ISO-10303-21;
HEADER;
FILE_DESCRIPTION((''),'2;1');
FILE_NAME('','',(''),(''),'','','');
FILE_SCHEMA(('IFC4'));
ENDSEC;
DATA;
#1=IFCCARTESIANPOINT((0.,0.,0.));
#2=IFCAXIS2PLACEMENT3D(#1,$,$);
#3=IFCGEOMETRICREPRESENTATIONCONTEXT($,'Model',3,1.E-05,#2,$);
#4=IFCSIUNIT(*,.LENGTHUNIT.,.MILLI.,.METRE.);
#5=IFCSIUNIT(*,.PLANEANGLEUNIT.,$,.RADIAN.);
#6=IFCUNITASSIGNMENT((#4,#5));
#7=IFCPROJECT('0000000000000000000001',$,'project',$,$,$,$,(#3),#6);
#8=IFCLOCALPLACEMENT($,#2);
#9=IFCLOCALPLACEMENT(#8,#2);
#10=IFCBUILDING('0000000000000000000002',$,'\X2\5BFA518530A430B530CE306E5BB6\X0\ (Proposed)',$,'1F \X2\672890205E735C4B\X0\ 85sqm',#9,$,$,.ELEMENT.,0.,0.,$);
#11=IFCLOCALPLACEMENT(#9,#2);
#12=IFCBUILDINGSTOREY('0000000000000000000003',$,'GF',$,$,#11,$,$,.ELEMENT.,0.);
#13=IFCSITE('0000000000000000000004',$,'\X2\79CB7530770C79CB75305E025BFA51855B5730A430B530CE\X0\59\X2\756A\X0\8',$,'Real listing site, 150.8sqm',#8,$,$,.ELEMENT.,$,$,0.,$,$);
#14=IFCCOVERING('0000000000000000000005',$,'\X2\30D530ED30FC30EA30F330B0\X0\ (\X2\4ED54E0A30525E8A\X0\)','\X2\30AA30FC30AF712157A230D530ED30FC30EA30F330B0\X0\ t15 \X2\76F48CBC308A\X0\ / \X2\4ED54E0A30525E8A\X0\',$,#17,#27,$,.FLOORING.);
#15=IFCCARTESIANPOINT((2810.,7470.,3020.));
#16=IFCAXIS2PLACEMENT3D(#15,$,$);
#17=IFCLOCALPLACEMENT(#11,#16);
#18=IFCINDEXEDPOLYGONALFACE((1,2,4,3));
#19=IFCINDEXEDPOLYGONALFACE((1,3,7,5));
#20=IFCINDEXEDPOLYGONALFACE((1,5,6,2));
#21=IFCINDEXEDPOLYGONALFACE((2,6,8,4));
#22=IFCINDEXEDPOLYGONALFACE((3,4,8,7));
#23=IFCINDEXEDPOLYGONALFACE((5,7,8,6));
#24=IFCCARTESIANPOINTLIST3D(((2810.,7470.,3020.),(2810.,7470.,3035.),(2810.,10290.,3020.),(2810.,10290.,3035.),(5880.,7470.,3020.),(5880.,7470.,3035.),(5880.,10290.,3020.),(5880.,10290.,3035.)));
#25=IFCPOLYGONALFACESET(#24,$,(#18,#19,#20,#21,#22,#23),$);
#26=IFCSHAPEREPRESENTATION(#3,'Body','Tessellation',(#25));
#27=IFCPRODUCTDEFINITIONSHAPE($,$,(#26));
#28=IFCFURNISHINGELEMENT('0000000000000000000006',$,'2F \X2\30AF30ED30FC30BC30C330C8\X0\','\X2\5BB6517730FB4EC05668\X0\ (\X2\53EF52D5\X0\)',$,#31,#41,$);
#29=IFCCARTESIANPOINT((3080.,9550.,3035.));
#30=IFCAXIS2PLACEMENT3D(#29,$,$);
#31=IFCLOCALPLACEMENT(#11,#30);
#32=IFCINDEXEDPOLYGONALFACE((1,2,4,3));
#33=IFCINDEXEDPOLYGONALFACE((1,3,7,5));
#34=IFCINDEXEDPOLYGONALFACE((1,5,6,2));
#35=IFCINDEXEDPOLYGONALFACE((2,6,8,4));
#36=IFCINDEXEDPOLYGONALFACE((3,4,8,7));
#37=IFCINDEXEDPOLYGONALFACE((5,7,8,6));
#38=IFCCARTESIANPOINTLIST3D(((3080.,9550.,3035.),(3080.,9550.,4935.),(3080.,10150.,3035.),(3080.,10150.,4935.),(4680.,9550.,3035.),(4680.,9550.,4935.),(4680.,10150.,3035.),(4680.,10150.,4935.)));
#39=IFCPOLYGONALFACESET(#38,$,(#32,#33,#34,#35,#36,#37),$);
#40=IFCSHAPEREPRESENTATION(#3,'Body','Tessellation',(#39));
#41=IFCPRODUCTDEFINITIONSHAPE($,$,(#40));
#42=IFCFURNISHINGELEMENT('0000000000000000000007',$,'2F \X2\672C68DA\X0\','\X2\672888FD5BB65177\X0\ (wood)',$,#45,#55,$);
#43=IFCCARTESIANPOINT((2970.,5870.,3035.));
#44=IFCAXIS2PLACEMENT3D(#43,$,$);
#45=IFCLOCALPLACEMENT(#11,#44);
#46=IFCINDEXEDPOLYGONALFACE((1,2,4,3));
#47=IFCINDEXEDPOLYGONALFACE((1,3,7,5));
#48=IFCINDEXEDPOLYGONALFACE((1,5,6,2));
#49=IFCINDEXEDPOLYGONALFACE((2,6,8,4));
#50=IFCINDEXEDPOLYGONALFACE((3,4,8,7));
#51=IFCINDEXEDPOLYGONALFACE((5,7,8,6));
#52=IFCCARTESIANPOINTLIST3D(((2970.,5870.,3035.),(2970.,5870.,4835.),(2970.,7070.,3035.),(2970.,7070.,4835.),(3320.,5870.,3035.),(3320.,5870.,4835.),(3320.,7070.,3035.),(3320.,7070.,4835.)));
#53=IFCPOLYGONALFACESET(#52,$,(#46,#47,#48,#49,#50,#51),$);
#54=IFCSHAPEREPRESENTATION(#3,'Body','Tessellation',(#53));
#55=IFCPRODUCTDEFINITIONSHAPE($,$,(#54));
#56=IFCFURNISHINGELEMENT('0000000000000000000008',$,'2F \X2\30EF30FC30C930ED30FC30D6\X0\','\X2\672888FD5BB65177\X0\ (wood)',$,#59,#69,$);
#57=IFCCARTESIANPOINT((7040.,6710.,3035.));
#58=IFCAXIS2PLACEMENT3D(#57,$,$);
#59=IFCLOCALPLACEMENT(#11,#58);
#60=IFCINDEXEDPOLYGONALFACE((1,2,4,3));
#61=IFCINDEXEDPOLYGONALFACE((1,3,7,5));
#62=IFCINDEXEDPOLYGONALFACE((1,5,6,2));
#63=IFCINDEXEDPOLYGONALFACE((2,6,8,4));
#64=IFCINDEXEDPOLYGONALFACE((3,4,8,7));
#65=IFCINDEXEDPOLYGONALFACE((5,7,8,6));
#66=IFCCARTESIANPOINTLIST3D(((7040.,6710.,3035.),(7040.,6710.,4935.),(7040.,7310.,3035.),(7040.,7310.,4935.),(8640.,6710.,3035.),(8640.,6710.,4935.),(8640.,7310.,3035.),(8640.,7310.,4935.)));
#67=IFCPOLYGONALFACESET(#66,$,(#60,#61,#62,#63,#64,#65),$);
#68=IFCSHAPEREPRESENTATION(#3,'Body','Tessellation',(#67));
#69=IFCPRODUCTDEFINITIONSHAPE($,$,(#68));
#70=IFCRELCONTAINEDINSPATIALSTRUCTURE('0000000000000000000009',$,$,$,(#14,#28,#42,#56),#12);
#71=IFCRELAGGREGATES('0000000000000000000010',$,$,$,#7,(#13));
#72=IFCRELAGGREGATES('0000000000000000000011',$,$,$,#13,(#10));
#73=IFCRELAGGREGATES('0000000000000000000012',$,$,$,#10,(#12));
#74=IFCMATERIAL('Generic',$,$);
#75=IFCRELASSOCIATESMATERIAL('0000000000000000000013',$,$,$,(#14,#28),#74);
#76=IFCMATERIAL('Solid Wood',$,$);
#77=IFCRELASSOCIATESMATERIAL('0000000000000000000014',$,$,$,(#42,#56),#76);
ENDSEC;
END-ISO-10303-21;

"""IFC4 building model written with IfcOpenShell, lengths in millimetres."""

from ifc_helpers import new_model, si_unit, frame, frame_2d, origin, place, context, project, spatial, rectangle, extrude, material, element, save


model = new_model("IFC4")

# Units and contexts
model_context = context("Model", 3, precision=1e-05, world=origin())
ifc_project = project(units=[si_unit("LENGTHUNIT", "METRE", prefix="MILLI"), si_unit("PLANEANGLEUNIT", "RADIAN")], contexts=[model_context])

# Site, building, storey
site_placement = place(None, origin())
site = spatial("IfcSite", under=ifc_project, at=site_placement, Name="秋田県秋田市寺内字イサノ59番8", ObjectType="Real listing site, 150.8sqm", CompositionType="ELEMENT", RefElevation=0.0)
building_placement = place(site_placement, origin())
building = spatial("IfcBuilding", under=site, at=building_placement, Name="寺内イサノの家 (Proposed)", ObjectType="1F 木造平屋 85sqm", CompositionType="ELEMENT", ElevationOfRefHeight=0.0, ElevationOfTerrain=0.0)
storey_placement = place(building_placement, origin())
storey = spatial("IfcBuildingStorey", under=building, at=storey_placement, Name="GF", CompositionType="ELEMENT", Elevation=0.0)

# Shared definitions
ifc_material_1 = material(Name="Solid Wood")

# Shared definitions
ifc_material_2 = material(Name="Generic")

# Covering
covering_placement = place(storey_placement, frame((2810.0, 7470.0, 3020.0)))
element("IfcCovering", 1, at=covering_placement, inside=storey, material=ifc_material_2, Name="フローリング (仕上げ床)", Description="オーク無垢フローリング t15 直貼り / 仕上げ床", PredefinedType="FLOORING", context=model_context, shape_type="SweptSolid", body=[
    extrude(rectangle(XDim=3070.0, YDim=2820.0, at=frame_2d((1535.0, 1410.0))), frame((2810.0, 7470.0, 3020.0)), (0.0, 0.0, 1.0), 15.0),
])

# Furnishing elements
furnishing_1_placement = place(storey_placement, frame((3080.0, 9550.0, 3035.0)))
element("IfcFurnishingElement", 2, at=furnishing_1_placement, inside=storey, material=ifc_material_2, Name="2F クローゼット", Description="家具・什器 (可動)", context=model_context, shape_type="SweptSolid", body=[
    extrude(rectangle(XDim=1600.0, YDim=600.0, at=frame_2d((800.0, 300.0))), frame((3080.0, 9550.0, 3035.0)), (0.0, 0.0, 1.0), 1900.0),
])
furnishing_2_placement = place(storey_placement, frame((2970.0, 5870.0, 3035.0)))
element("IfcFurnishingElement", 3, at=furnishing_2_placement, inside=storey, material=ifc_material_1, Name="2F 本棚", Description="木製家具 (wood)", context=model_context, shape_type="SweptSolid", body=[
    extrude(rectangle(XDim=350.0, YDim=1200.0, at=frame_2d((175.0, 600.0))), frame((2970.0, 5870.0, 3035.0)), (0.0, 0.0, 1.0), 1800.0),
])
furnishing_3_placement = place(storey_placement, frame((7040.0, 6710.0, 3035.0)))
element("IfcFurnishingElement", 4, at=furnishing_3_placement, inside=storey, material=ifc_material_1, Name="2F ワードローブ", Description="木製家具 (wood)", context=model_context, shape_type="SweptSolid", body=[
    extrude(rectangle(XDim=1600.0, YDim=600.0, at=frame_2d((800.0, 300.0))), frame((7040.0, 6710.0, 3035.0)), (0.0, 0.0, 1.0), 1900.0),
])

save(model, "model.ifc")
